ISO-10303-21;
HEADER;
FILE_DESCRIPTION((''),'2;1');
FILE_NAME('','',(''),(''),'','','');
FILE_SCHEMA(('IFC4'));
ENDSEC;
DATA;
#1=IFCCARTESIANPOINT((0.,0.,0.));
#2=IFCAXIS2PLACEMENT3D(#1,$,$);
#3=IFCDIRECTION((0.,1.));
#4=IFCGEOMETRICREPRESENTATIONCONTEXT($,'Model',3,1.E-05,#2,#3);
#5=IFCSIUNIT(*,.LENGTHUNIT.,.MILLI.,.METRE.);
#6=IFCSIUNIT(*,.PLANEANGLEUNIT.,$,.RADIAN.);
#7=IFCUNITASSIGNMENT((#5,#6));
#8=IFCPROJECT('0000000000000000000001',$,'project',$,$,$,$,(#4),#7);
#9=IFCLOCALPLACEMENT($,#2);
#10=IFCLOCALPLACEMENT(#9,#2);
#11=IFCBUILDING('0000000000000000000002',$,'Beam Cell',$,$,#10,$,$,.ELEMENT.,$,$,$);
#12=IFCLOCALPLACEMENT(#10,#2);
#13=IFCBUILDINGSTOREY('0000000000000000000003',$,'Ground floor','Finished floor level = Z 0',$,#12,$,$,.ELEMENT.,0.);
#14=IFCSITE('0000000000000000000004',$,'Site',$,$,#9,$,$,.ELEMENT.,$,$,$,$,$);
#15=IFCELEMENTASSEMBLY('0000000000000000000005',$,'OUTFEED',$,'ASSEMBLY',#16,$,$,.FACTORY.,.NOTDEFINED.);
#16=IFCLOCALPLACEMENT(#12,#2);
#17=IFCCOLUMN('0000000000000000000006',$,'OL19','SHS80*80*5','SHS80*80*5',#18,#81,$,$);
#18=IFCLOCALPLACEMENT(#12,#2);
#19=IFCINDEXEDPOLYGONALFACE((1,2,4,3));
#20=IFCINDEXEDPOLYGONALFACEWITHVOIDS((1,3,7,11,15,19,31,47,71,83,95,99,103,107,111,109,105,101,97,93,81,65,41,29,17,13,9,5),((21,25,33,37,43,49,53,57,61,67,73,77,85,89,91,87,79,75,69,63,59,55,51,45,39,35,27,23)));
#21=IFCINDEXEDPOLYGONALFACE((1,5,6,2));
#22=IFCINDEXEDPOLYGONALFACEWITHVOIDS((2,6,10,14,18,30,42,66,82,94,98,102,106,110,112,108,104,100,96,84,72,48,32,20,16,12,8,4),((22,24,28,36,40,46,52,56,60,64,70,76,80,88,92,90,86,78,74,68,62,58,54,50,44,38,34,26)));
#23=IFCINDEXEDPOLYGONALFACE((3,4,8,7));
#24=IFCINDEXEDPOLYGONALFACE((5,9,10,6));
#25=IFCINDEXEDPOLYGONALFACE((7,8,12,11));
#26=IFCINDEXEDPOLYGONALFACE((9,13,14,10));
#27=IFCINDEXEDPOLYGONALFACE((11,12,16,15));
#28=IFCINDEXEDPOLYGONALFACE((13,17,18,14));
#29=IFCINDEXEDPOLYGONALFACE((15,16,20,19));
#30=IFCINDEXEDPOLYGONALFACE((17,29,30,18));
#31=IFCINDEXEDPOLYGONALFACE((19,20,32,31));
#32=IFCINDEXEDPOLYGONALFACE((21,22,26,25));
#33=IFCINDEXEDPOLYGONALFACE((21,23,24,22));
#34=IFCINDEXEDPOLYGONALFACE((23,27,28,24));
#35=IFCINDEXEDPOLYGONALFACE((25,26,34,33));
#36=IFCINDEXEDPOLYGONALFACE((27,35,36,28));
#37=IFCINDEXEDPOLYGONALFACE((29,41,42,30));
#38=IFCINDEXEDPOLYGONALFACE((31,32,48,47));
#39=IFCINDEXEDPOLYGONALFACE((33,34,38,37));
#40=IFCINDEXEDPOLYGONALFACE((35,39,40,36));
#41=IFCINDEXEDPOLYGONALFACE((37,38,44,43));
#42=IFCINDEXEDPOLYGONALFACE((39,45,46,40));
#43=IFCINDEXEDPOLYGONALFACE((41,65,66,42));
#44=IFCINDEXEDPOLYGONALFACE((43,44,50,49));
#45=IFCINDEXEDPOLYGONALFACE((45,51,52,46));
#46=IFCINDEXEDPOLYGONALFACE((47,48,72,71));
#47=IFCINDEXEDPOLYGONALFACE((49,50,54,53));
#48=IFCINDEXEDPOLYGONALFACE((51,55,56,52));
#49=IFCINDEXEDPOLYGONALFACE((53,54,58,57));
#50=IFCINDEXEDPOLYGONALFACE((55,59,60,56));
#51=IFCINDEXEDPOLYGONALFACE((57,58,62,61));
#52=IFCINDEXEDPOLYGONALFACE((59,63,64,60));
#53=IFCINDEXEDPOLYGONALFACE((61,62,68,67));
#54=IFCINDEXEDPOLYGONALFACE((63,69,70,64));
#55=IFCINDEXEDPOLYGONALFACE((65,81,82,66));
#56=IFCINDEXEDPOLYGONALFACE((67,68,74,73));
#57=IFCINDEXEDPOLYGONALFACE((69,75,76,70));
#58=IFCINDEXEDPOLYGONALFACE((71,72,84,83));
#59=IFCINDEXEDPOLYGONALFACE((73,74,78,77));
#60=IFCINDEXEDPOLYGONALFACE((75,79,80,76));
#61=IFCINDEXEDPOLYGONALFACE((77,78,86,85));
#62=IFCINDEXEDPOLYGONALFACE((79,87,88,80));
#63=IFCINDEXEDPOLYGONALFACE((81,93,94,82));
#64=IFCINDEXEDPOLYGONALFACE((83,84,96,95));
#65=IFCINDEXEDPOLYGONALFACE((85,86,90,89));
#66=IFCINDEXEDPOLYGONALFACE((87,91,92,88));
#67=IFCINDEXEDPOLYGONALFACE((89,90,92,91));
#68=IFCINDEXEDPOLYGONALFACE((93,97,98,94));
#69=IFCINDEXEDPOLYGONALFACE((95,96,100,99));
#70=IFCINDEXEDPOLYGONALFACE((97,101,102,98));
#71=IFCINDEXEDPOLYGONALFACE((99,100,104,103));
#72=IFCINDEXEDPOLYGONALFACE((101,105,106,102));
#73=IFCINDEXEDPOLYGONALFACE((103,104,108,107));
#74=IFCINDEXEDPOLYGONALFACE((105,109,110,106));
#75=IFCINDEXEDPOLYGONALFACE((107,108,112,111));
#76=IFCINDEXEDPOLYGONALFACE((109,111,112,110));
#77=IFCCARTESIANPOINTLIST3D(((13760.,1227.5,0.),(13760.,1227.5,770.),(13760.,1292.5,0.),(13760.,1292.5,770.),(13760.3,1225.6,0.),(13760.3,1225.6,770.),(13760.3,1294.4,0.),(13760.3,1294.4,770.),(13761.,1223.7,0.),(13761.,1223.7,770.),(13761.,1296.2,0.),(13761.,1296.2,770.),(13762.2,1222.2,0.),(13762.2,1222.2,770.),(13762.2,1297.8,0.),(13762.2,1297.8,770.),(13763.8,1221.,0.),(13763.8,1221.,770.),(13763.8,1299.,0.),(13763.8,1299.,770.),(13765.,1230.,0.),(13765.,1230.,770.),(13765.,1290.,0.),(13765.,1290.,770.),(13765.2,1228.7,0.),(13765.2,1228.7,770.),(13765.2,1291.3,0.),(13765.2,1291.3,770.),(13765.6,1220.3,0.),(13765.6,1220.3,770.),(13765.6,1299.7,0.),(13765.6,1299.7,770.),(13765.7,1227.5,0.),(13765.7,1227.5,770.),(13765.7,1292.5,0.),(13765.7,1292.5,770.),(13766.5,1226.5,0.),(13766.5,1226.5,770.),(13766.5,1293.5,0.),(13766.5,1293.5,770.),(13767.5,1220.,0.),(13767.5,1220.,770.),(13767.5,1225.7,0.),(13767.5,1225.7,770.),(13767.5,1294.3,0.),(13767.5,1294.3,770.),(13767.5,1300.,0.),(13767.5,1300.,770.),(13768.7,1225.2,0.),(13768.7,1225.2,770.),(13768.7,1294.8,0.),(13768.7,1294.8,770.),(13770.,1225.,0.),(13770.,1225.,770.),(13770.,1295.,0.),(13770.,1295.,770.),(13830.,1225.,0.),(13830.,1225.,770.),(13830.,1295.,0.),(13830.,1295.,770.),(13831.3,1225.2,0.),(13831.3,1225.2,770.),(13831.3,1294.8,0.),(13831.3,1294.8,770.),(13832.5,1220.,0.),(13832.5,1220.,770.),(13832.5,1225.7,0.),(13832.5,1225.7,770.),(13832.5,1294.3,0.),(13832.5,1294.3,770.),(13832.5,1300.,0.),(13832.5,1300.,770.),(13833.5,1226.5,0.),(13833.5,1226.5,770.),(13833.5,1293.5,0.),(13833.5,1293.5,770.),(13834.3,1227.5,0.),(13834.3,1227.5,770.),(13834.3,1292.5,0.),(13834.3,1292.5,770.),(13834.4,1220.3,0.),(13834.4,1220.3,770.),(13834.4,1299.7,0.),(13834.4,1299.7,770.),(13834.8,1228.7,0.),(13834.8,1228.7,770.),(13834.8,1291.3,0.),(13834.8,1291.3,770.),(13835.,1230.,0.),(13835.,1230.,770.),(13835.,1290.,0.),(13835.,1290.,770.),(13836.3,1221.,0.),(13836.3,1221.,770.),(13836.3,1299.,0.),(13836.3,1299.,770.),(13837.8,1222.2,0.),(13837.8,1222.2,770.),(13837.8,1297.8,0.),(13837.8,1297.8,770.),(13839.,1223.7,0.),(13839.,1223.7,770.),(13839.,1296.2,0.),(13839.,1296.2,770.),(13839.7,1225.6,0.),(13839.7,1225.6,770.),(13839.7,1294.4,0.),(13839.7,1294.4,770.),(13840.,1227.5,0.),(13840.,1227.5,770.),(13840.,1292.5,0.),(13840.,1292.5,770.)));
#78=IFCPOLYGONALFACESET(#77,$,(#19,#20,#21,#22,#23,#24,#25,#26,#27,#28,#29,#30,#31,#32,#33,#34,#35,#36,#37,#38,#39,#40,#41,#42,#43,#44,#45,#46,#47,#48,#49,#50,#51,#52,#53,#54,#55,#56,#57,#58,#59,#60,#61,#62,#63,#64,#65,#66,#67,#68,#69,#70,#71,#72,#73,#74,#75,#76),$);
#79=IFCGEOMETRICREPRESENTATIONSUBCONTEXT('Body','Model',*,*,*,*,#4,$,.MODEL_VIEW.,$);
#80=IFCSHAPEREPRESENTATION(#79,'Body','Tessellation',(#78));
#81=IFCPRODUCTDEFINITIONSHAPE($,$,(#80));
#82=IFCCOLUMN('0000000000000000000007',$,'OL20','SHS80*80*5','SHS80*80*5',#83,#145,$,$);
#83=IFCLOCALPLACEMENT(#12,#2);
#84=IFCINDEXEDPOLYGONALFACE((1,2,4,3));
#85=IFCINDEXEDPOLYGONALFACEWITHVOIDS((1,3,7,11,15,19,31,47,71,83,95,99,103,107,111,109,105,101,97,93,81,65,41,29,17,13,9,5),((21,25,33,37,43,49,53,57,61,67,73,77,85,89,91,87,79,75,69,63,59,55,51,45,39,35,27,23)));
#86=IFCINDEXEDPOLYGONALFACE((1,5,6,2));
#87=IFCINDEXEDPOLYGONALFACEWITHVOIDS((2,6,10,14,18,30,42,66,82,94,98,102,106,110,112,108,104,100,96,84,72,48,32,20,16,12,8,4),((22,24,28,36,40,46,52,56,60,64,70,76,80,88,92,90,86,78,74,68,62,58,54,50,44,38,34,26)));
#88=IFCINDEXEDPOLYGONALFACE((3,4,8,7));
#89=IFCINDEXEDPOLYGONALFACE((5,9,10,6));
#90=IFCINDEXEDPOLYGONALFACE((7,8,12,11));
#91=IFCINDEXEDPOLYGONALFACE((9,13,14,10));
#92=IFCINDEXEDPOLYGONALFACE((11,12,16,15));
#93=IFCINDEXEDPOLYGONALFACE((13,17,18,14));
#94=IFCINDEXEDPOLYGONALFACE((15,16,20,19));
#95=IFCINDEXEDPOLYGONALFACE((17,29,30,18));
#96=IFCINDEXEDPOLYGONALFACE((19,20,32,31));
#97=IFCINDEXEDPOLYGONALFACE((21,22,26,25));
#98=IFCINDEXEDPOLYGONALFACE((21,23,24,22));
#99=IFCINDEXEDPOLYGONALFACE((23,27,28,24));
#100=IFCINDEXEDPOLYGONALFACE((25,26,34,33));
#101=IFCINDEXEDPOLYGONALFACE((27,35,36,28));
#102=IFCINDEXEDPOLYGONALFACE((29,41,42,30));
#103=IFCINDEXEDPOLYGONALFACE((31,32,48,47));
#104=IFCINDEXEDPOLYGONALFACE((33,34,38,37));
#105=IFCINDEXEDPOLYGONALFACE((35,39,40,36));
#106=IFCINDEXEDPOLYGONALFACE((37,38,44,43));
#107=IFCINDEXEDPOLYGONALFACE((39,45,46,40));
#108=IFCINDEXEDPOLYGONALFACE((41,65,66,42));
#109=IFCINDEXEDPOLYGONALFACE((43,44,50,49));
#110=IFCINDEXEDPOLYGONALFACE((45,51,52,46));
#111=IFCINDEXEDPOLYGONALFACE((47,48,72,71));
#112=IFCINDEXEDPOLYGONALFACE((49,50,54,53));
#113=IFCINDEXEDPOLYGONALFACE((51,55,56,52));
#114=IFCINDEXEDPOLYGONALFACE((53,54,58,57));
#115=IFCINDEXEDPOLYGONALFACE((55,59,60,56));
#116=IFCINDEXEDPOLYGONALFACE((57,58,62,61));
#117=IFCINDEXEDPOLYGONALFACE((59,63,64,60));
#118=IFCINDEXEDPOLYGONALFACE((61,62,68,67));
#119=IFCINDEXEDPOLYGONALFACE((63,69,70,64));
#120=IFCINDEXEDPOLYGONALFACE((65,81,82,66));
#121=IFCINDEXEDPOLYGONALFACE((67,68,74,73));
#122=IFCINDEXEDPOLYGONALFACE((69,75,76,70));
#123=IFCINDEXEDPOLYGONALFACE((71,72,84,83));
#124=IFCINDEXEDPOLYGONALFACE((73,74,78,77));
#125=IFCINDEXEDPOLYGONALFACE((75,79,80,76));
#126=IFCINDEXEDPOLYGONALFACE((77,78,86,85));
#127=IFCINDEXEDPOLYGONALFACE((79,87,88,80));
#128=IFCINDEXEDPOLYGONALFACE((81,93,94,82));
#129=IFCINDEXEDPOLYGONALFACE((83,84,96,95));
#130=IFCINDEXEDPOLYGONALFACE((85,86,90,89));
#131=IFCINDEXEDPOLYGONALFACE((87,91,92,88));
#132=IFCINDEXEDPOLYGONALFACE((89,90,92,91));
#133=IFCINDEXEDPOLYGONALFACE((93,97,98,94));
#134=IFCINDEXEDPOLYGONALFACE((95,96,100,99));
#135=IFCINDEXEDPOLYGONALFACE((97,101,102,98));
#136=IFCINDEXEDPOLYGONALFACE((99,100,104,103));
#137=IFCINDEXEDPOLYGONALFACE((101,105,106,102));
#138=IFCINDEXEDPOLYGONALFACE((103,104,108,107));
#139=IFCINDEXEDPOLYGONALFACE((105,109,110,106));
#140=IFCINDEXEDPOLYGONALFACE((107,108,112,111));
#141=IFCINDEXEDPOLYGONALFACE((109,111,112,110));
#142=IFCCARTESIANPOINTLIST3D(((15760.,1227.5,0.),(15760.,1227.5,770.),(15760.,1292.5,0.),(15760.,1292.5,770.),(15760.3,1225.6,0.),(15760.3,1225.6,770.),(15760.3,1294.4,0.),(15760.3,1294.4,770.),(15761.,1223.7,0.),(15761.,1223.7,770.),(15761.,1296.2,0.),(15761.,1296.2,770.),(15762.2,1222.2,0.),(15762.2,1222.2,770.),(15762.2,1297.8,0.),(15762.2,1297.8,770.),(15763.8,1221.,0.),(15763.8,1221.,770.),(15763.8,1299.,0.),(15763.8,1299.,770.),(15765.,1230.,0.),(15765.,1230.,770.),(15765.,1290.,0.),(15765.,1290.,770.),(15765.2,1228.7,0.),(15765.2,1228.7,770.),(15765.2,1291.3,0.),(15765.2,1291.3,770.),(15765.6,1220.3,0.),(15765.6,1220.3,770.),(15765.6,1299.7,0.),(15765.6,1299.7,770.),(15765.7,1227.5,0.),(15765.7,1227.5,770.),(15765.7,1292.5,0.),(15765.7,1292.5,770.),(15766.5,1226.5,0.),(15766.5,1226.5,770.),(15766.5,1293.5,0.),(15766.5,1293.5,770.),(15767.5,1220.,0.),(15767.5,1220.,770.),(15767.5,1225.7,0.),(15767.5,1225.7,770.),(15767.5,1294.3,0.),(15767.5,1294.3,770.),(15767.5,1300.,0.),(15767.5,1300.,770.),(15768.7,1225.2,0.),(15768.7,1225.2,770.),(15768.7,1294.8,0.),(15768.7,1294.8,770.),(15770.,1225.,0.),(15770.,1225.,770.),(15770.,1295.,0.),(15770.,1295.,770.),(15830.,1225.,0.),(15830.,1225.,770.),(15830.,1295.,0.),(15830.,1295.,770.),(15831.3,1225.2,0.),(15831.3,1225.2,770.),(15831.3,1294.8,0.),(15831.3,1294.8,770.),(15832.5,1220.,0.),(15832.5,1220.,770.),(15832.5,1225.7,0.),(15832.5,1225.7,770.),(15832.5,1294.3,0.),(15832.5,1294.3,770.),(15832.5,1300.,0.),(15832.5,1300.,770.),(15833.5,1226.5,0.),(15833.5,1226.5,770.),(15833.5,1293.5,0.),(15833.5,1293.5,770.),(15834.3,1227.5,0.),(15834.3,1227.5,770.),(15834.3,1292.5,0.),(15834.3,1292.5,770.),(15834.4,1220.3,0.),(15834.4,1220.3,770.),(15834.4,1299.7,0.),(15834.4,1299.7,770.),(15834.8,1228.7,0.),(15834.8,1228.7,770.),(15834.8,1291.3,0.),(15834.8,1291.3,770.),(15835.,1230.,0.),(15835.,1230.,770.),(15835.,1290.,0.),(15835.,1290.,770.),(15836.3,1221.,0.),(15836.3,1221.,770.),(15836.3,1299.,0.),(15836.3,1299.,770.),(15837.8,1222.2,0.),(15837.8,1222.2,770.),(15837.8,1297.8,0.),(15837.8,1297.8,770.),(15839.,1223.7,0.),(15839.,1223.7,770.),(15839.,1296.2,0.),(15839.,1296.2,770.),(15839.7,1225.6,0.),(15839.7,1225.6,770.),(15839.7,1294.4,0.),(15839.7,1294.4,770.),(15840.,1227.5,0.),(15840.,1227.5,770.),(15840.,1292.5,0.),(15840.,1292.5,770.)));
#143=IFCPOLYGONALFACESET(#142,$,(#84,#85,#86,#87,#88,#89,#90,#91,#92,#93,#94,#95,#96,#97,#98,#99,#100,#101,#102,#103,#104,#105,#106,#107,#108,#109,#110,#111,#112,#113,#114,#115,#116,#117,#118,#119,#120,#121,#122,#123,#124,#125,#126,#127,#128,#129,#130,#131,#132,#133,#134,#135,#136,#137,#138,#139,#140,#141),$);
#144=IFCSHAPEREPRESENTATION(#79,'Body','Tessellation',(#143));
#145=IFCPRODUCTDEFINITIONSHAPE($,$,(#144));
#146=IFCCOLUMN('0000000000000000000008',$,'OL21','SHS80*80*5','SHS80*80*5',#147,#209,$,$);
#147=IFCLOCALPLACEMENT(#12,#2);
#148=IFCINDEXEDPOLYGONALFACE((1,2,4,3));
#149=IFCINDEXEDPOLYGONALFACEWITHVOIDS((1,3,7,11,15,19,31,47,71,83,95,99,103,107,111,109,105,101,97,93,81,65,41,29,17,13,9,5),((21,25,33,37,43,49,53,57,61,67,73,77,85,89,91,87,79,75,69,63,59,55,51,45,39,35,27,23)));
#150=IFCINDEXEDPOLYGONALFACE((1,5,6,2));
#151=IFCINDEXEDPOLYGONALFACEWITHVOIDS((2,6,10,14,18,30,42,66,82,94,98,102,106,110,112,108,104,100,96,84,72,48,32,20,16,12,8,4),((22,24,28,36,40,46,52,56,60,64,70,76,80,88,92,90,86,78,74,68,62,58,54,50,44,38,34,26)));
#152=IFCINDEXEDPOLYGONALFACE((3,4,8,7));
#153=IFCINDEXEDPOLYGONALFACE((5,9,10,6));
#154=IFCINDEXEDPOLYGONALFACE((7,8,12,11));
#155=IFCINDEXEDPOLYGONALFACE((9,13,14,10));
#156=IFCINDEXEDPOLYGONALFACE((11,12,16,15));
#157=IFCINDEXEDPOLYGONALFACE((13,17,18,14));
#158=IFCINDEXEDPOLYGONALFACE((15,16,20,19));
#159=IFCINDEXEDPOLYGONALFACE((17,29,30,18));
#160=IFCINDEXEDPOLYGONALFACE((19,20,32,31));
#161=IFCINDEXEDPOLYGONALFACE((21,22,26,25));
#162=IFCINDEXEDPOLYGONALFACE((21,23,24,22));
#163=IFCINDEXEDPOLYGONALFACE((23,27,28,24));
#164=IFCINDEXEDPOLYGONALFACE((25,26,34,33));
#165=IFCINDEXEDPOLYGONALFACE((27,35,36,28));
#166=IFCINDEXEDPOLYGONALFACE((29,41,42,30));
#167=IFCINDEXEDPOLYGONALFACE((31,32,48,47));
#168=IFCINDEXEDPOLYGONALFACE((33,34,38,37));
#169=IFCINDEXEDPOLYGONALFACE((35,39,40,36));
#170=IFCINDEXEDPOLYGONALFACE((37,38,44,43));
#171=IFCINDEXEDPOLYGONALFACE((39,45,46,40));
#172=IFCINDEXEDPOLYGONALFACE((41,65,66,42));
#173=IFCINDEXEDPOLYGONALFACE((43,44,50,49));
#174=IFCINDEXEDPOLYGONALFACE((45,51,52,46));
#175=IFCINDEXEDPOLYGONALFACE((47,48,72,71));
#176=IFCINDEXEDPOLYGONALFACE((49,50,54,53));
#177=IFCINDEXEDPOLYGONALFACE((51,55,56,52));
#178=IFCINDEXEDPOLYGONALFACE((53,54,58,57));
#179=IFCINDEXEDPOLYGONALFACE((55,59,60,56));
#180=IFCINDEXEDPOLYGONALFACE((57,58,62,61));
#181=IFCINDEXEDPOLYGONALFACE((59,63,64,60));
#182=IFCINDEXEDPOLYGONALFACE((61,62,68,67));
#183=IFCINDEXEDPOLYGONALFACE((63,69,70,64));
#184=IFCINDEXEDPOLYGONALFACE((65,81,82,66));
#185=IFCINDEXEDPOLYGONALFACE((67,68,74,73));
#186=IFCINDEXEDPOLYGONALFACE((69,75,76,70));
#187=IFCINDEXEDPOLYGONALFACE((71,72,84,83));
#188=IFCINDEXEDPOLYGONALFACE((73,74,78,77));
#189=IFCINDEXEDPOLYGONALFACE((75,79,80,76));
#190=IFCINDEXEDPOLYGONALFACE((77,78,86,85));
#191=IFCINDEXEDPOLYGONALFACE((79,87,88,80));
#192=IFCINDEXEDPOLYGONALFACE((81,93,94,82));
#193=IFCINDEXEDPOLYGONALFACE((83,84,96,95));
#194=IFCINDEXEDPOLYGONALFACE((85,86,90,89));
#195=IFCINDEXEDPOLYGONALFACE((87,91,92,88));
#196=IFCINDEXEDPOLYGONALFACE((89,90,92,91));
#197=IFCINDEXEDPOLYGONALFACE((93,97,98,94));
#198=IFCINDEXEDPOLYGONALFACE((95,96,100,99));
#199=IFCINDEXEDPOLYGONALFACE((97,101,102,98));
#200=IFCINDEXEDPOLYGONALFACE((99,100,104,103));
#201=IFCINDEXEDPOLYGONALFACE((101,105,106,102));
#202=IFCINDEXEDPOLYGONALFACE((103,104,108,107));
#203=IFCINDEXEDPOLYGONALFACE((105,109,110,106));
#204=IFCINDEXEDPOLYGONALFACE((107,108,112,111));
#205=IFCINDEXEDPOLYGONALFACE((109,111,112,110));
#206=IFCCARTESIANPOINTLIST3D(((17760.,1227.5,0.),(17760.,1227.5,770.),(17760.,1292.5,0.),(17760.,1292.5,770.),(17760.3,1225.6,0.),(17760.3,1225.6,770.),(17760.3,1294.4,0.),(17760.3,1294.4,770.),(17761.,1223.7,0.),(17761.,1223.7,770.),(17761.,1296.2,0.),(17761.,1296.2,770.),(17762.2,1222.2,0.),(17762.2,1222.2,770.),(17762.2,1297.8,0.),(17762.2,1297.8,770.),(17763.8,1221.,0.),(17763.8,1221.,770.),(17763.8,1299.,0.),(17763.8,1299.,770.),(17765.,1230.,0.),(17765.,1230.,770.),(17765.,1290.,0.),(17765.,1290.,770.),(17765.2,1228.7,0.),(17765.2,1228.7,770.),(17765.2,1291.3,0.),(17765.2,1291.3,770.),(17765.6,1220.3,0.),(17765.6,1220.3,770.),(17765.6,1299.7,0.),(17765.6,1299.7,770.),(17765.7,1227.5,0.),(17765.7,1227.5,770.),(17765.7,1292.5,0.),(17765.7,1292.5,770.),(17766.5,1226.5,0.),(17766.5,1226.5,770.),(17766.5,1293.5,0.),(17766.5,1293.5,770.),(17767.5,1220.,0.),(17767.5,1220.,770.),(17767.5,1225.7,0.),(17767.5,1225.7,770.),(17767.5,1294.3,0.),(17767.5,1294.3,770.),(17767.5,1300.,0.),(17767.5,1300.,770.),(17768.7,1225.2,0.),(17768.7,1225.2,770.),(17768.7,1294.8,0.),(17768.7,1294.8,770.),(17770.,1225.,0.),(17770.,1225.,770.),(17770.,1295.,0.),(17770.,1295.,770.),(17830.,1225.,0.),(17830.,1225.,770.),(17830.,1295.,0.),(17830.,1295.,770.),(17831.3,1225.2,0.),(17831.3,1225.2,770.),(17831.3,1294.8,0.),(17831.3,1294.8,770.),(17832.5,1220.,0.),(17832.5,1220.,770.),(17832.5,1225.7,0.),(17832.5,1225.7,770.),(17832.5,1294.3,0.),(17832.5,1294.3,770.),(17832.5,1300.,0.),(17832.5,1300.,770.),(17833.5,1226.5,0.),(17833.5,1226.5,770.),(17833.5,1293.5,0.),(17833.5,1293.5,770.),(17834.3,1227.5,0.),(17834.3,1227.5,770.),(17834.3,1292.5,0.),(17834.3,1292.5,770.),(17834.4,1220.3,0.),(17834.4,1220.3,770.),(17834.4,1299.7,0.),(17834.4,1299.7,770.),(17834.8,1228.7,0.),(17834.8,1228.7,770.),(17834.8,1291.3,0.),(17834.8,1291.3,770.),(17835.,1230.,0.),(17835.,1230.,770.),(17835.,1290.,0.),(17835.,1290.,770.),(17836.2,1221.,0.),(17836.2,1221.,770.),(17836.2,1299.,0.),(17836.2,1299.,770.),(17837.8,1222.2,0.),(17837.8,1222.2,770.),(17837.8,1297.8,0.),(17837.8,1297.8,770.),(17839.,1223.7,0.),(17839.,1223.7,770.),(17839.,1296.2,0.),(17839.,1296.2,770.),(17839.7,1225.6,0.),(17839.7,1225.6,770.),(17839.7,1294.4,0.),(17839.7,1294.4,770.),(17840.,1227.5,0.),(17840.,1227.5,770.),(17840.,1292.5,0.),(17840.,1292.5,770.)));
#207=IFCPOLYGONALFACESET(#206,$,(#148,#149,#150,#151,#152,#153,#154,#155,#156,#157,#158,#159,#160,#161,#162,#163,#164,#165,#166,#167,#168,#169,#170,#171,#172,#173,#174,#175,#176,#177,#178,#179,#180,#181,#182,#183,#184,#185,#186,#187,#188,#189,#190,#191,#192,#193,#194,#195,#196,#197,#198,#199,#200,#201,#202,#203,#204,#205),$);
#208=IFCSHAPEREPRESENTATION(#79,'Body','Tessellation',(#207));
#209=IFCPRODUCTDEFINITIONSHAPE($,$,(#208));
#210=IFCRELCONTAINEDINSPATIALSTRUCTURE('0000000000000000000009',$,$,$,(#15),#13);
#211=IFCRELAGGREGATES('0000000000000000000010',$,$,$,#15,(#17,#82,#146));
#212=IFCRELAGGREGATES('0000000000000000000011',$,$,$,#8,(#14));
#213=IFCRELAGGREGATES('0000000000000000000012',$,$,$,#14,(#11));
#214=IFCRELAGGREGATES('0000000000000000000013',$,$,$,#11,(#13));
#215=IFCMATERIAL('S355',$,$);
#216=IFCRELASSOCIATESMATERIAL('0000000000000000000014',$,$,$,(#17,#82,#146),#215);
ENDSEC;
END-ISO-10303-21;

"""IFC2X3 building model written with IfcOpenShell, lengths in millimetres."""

from ifc_helpers import new_model, si_unit, direction, frame, origin, origin_2d, place, context, subcontext, project, spatial, hollow_rectangle, extrude, material, element, aggregate, save


model = new_model("IFC2X3")

# Units and contexts
model_context = context("Model", 3, precision=1e-05, world=origin(), true_north=direction((0.0, 1.0)))
body_context = subcontext(model_context, "Body", "Model", "MODEL_VIEW")
ifc_project = project(units=[si_unit("LENGTHUNIT", "METRE", prefix="MILLI"), si_unit("PLANEANGLEUNIT", "RADIAN")], contexts=[model_context])

# Site, building, storey
site_placement = place(None, origin())
site = spatial("IfcSite", under=ifc_project, at=site_placement, Name="Site", CompositionType="ELEMENT")
building_placement = place(site_placement, origin())
building = spatial("IfcBuilding", under=site, at=building_placement, Name="Beam Cell", CompositionType="ELEMENT")
storey_placement = place(building_placement, origin())
storey = spatial("IfcBuildingStorey", under=building, at=storey_placement, Name="Ground floor", Description="Finished floor level = Z 0", CompositionType="ELEMENT", Elevation=0.0)

# Element assembly, columns
ifc_material = material(Name="S355")
assembly_1_placement = place(storey_placement, origin())
assembly_1 = element("IfcElementAssembly", 1, at=assembly_1_placement, inside=storey, Name="OUTFEED", ObjectType="ASSEMBLY", AssemblyPlace="FACTORY", PredefinedType="NOTDEFINED")
column_1_placement = place(storey_placement, frame((13800.0, 1260.0, 0.0), z_axis=(0.0, 0.0, 1.0), x_axis=(1.0, 0.0, 0.0)))
column_1 = element("IfcColumn", 2, at=column_1_placement, material=ifc_material, Name="OL19", Description="SHS80*80*5", ObjectType="SHS80*80*5", context=body_context, shape_type="SweptSolid", body=[
    extrude(hollow_rectangle(XDim=80.0, YDim=80.0, WallThickness=5.0, InnerFilletRadius=5.0, OuterFilletRadius=7.5, at=origin_2d()), origin(), (0.0, 0.0, 1.0), 770.0),
])
column_2_placement = place(storey_placement, frame((15800.0, 1260.0, 0.0), z_axis=(0.0, 0.0, 1.0), x_axis=(1.0, 0.0, 0.0)))
column_2 = element("IfcColumn", 3, at=column_2_placement, material=ifc_material, Name="OL20", Description="SHS80*80*5", ObjectType="SHS80*80*5", context=body_context, shape_type="SweptSolid", body=[
    extrude(hollow_rectangle(XDim=80.0, YDim=80.0, WallThickness=5.0, InnerFilletRadius=5.0, OuterFilletRadius=7.5, at=origin_2d()), origin(), (0.0, 0.0, 1.0), 770.0),
])
column_3_placement = place(storey_placement, frame((17800.0, 1260.0, 0.0), z_axis=(0.0, 0.0, 1.0), x_axis=(1.0, 0.0, 0.0)))
column_3 = element("IfcColumn", 4, at=column_3_placement, material=ifc_material, Name="OL21", Description="SHS80*80*5", ObjectType="SHS80*80*5", context=body_context, shape_type="SweptSolid", body=[
    extrude(hollow_rectangle(XDim=80.0, YDim=80.0, WallThickness=5.0, InnerFilletRadius=5.0, OuterFilletRadius=7.5, at=origin_2d()), origin(), (0.0, 0.0, 1.0), 770.0),
])
aggregate(assembly_1, [column_1, column_2, column_3])

save(model, "model.ifc")
